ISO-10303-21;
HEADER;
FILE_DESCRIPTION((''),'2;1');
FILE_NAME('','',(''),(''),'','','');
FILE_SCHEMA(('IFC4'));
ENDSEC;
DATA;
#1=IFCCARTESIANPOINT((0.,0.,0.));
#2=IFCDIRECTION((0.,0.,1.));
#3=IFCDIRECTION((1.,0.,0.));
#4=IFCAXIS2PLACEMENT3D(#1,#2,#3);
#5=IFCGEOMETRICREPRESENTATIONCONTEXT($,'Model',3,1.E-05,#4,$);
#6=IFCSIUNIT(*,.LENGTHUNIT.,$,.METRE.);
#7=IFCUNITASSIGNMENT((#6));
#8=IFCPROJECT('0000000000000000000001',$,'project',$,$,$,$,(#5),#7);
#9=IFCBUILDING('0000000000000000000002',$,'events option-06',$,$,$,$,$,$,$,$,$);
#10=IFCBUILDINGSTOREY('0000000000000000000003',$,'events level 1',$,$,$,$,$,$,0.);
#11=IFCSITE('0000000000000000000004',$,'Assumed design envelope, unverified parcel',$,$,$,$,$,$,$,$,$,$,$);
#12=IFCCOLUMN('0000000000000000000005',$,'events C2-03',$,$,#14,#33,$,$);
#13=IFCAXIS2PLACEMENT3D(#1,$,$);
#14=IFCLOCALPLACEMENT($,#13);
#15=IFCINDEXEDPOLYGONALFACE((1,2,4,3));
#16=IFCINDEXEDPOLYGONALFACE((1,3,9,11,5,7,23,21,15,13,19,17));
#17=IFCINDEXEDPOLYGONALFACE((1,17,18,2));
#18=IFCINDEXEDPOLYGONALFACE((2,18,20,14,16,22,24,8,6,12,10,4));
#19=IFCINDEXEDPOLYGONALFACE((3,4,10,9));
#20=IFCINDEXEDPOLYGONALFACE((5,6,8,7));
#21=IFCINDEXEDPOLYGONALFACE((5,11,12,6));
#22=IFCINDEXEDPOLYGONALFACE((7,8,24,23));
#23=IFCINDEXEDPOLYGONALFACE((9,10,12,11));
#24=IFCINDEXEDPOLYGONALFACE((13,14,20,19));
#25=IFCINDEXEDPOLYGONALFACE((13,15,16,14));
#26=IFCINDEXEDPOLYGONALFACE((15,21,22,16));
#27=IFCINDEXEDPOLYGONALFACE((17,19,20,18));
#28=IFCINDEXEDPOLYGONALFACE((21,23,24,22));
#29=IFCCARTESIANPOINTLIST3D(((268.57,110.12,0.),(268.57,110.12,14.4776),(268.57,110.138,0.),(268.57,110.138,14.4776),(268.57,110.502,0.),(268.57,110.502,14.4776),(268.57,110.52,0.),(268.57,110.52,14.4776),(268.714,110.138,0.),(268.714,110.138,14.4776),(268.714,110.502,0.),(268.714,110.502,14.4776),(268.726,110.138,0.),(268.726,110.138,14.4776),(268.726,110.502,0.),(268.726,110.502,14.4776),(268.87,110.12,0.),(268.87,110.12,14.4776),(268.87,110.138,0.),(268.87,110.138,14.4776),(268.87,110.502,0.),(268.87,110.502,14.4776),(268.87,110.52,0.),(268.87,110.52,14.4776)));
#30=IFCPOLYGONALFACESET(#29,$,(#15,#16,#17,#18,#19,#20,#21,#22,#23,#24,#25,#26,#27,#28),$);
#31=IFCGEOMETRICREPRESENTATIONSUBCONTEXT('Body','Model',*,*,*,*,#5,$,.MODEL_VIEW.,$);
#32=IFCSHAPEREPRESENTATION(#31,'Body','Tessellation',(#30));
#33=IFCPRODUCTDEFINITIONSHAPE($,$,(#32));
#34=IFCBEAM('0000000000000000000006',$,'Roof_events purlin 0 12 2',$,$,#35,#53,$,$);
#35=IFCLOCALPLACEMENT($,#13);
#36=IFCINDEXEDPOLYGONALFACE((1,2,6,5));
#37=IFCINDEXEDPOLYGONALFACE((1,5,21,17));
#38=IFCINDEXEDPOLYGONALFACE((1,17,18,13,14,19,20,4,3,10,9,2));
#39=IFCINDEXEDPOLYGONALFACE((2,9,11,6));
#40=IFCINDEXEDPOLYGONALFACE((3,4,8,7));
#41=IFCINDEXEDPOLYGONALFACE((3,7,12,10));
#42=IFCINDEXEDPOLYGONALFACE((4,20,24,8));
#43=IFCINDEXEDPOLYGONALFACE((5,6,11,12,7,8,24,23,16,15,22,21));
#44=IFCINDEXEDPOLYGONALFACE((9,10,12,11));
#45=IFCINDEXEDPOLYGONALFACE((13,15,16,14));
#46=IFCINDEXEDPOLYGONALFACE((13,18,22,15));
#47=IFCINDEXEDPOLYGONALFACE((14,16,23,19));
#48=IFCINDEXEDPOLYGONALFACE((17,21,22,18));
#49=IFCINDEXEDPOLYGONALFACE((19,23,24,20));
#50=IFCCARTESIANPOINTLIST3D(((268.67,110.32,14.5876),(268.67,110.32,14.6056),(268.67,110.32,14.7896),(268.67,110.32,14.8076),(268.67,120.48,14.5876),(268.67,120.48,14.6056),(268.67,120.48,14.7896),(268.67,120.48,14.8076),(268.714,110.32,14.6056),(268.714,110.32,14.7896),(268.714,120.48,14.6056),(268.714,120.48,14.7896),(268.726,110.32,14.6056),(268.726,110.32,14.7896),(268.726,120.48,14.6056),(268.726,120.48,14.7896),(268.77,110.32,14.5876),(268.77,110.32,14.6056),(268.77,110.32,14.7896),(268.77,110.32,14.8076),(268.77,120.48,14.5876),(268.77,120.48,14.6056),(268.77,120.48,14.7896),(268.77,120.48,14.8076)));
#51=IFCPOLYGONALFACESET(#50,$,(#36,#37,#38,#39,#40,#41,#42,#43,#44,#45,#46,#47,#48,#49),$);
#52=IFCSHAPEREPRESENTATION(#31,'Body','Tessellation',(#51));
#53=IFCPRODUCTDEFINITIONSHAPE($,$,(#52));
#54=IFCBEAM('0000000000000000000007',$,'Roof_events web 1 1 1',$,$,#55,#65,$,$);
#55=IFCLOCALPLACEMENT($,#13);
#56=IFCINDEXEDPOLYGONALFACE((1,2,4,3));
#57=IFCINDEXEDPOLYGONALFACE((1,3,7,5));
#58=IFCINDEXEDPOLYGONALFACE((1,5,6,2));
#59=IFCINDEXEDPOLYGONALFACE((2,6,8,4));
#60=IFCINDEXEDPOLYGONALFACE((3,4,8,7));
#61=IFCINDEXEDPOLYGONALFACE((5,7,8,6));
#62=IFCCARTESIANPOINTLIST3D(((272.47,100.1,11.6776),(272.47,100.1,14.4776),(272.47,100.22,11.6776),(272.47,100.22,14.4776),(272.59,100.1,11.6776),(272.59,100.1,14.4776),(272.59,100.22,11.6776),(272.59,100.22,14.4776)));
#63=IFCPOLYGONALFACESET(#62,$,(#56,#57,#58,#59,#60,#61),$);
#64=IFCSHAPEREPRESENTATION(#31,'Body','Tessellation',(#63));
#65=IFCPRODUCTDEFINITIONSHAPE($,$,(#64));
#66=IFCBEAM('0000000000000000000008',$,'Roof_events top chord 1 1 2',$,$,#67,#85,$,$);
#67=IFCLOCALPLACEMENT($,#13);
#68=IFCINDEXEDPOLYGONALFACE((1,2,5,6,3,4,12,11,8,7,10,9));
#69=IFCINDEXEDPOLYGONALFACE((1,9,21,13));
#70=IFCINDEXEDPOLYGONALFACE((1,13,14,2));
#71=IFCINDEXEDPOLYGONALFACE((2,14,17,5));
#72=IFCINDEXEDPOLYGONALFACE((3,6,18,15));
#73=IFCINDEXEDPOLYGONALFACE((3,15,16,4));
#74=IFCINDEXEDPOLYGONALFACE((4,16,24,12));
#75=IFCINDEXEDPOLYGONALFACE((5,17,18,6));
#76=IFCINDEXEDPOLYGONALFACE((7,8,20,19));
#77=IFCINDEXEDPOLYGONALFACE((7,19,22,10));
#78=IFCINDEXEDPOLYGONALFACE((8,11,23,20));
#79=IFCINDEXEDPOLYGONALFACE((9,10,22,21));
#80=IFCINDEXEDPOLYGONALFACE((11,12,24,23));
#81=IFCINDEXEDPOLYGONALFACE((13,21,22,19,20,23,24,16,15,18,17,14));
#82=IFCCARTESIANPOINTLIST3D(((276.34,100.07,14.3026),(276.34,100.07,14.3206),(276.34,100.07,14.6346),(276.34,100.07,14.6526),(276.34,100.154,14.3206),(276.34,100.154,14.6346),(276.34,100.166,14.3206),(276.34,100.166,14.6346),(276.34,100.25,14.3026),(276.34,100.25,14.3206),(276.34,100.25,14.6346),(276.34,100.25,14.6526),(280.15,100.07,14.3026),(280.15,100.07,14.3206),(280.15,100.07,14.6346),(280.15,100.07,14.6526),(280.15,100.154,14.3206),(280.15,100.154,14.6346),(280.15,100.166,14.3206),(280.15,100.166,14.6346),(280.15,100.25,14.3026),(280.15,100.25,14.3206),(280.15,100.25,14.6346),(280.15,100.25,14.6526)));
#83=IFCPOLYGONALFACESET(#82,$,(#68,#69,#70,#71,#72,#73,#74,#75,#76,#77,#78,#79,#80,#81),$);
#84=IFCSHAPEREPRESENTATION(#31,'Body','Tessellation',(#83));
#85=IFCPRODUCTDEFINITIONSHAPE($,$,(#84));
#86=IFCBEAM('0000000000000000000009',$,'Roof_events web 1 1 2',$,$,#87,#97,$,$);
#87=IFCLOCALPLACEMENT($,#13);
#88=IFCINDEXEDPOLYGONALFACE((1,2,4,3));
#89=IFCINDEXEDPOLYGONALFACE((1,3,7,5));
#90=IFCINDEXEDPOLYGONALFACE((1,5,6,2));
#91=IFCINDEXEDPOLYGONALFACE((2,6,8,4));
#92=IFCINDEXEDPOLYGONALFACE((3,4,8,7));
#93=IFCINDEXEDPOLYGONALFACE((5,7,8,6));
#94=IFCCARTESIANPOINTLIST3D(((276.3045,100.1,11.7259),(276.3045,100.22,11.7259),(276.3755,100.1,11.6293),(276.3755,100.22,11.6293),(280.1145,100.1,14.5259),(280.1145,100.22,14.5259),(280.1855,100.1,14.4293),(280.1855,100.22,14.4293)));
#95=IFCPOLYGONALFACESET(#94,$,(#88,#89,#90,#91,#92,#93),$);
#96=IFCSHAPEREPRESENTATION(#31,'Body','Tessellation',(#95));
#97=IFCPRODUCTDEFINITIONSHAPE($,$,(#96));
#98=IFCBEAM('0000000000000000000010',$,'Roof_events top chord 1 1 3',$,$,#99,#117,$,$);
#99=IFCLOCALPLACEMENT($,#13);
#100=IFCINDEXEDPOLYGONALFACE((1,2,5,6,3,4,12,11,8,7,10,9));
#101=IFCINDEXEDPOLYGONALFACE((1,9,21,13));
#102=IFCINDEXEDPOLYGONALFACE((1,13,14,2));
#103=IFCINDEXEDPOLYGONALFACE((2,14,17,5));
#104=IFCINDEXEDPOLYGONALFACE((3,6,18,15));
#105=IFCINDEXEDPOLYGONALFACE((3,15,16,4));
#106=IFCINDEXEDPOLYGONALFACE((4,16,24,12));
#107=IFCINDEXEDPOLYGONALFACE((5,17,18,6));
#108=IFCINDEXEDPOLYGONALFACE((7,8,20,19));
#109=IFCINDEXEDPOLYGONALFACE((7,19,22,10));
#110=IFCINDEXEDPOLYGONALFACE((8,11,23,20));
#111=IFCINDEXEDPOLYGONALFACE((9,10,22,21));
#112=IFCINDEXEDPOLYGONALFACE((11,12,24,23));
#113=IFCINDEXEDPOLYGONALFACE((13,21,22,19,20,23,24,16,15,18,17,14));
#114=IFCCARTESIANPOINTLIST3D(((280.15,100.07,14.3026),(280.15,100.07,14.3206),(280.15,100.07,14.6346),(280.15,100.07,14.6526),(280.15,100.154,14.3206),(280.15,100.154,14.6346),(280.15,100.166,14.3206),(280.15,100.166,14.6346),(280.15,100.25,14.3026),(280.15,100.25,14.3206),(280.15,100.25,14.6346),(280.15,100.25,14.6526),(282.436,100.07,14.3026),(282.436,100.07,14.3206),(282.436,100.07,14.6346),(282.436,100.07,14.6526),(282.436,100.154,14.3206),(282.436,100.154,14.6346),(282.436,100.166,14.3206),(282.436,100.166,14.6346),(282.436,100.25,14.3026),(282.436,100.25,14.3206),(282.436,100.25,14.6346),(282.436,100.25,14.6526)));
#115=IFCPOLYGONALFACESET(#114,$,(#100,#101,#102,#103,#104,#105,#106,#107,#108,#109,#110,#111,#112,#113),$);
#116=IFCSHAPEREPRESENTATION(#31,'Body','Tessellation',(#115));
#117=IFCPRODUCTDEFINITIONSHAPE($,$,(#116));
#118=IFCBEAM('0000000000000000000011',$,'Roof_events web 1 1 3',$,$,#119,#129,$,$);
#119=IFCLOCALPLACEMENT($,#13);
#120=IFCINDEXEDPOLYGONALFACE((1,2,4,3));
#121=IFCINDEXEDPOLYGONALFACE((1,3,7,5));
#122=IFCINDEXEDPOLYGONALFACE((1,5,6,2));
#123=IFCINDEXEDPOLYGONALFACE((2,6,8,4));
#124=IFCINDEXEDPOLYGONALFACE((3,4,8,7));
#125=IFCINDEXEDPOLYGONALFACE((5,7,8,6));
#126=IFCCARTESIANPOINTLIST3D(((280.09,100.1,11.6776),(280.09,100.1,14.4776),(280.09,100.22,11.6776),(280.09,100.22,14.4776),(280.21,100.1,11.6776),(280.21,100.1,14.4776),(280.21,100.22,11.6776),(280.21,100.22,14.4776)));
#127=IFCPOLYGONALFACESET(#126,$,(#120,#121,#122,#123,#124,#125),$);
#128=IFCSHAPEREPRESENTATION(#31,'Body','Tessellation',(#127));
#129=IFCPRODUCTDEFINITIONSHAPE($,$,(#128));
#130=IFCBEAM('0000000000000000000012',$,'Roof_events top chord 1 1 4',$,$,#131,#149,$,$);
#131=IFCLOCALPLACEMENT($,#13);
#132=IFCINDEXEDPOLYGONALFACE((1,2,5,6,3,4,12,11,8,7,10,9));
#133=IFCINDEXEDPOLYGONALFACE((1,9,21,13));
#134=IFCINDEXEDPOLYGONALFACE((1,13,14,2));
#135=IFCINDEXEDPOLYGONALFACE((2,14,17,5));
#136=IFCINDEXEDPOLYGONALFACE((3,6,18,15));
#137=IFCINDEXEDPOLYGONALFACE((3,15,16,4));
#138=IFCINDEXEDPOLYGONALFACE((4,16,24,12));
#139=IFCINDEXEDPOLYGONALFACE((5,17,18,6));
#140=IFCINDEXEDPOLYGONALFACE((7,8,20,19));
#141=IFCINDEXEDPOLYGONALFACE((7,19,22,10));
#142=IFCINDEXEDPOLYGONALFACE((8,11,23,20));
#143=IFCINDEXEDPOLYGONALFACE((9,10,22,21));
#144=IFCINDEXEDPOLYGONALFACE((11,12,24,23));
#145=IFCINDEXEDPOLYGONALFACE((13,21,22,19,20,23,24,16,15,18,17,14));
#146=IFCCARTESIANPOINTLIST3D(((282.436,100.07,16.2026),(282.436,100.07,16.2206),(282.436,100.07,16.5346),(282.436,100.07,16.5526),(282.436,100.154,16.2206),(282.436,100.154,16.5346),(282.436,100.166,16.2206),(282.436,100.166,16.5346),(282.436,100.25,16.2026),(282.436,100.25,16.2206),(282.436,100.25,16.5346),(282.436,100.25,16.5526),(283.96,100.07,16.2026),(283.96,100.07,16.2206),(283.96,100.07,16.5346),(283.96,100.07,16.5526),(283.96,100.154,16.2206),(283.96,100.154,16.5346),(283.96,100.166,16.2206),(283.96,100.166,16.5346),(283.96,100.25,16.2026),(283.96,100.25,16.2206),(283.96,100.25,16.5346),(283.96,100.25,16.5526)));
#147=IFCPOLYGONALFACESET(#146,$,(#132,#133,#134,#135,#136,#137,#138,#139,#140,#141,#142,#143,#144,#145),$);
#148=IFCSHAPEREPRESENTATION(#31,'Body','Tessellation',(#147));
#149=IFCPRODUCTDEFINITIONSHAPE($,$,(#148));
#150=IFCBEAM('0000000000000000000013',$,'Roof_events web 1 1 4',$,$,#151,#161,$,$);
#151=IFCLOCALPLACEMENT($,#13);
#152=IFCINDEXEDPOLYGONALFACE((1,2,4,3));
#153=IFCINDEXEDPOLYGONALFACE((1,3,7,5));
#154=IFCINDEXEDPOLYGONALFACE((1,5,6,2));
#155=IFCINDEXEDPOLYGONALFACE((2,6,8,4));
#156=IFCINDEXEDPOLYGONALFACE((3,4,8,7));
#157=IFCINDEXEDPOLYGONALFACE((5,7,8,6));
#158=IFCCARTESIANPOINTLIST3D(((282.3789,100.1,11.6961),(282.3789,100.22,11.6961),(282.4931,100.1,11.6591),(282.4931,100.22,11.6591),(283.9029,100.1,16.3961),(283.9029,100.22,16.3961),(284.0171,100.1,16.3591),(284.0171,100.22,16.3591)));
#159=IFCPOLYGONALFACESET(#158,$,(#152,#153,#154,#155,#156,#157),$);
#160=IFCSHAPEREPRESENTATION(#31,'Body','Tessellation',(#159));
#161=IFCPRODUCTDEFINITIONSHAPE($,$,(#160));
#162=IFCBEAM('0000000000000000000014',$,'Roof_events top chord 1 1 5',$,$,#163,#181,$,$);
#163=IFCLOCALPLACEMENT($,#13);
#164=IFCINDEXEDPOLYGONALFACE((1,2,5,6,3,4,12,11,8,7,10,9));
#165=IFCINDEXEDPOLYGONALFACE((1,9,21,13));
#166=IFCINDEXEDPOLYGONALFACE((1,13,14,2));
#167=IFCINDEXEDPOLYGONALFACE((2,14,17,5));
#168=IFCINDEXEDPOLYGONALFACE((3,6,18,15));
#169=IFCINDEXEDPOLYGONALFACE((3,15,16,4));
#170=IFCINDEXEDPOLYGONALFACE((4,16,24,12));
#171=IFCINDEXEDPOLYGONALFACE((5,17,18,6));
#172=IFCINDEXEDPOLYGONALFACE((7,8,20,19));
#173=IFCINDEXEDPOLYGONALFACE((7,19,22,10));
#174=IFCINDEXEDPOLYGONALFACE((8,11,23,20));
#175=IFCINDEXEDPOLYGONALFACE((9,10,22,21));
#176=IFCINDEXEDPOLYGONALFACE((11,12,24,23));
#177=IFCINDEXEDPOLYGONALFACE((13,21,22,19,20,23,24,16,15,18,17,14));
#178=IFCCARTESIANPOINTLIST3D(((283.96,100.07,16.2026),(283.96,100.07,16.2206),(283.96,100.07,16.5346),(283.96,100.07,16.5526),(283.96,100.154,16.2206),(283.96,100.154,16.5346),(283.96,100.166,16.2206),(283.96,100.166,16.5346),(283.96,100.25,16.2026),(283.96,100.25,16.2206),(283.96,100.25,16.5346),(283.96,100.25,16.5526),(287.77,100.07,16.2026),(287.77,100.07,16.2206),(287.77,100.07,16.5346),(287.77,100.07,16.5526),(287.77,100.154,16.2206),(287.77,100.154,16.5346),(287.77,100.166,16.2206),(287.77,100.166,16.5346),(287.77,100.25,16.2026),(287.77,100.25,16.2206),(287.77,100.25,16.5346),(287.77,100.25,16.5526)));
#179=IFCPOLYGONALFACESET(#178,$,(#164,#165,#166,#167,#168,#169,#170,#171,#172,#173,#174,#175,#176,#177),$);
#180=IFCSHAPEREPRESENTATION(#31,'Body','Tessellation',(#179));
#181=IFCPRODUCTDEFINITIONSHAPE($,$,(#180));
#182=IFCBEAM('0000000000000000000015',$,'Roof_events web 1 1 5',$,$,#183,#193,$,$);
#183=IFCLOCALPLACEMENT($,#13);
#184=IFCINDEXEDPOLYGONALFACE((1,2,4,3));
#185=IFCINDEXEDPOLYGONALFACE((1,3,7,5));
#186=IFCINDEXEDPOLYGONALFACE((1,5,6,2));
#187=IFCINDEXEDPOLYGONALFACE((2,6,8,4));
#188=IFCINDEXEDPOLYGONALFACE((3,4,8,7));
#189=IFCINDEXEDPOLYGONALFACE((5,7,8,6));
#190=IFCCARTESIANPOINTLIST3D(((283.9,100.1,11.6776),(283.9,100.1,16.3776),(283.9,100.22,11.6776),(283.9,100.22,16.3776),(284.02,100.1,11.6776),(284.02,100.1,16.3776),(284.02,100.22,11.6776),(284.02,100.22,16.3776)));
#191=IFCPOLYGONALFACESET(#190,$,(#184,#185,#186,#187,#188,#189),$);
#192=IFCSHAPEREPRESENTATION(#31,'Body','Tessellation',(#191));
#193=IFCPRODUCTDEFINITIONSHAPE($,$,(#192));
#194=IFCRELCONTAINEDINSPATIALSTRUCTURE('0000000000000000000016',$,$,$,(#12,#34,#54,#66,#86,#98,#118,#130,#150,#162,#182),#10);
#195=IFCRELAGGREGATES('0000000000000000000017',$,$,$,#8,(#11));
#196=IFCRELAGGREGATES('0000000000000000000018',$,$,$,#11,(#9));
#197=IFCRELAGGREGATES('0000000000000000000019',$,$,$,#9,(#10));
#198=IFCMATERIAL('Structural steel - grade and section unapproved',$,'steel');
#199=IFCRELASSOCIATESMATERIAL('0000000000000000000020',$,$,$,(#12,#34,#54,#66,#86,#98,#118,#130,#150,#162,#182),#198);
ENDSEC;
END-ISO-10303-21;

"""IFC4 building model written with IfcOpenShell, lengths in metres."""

from ifc_helpers import new_model, si_unit, frame, origin_with_axes, place, context, subcontext, project, spatial, rectangle, i_section, extrude, material, element, save


model = new_model("IFC4")

# Units and contexts
model_context = context("Model", 3, precision=1e-05, world=origin_with_axes())
body_context = subcontext(model_context, "Body", "Model", "MODEL_VIEW")
ifc_project = project(units=[si_unit("LENGTHUNIT", "METRE")], contexts=[model_context])

# Site, building, storey
site = spatial("IfcSite", under=ifc_project, Name="Assumed design envelope, unverified parcel")
building = spatial("IfcBuilding", under=site, Name="events option-06")
storey = spatial("IfcBuildingStorey", under=building, Name="events level 1", Elevation=0.0)

# Column
ifc_material = material(Name="Structural steel - grade and section unapproved", Category="steel")
column_placement = place(None, frame((268.72, 110.32, 0.0), z_axis=(0.0, 0.0, 1.0), x_axis=(-1.0, 0.0, 0.0)))
element("IfcColumn", 1, at=column_placement, inside=storey, material=ifc_material, Name="events C2-03", context=body_context, shape_type="SweptSolid", body=[
    extrude(i_section(OverallWidth=0.3, OverallDepth=0.4, WebThickness=0.012, FlangeThickness=0.018, FilletRadius=0.0), origin_with_axes(), (0.0, 0.0, 1.0), 14.4776),
])

# Beams
beam_1_placement = place(None, frame((268.72, 110.32, 14.6976), z_axis=(0.0, 1.0, 0.0), x_axis=(-1.0, 0.0, 0.0)))
element("IfcBeam", 2, at=beam_1_placement, inside=storey, material=ifc_material, Name="Roof_events purlin 0 12 2", context=body_context, shape_type="SweptSolid", body=[
    extrude(i_section(OverallWidth=0.1, OverallDepth=0.22, WebThickness=0.012, FlangeThickness=0.018, FilletRadius=0.0), origin_with_axes(), (0.0, 0.0, 1.0), 10.16),
])
beam_2_placement = place(None, frame((272.53, 100.16, 11.6776), z_axis=(0.0, 0.0, 1.0), x_axis=(-1.0, 0.0, 0.0)))
element("IfcBeam", 3, at=beam_2_placement, inside=storey, material=ifc_material, Name="Roof_events web 1 1 1", context=body_context, shape_type="SweptSolid", body=[
    extrude(rectangle(XDim=0.12, YDim=0.12), origin_with_axes(), (0.0, 0.0, 1.0), 2.8),
])
beam_3_placement = place(None, frame((276.34, 100.16, 14.4776), z_axis=(1.0, 0.0, 0.0), x_axis=(0.0, 1.0, 0.0)))
element("IfcBeam", 4, at=beam_3_placement, inside=storey, material=ifc_material, Name="Roof_events top chord 1 1 2", context=body_context, shape_type="SweptSolid", body=[
    extrude(i_section(OverallWidth=0.18, OverallDepth=0.35, WebThickness=0.012, FlangeThickness=0.018, FilletRadius=0.0), origin_with_axes(), (0.0, 0.0, 1.0), 3.81),
])
beam_4_placement = place(None, frame((276.34, 100.16, 11.6776), z_axis=(0.805799, 0.0, 0.592189), x_axis=(0.0, 1.0, 0.0)))
element("IfcBeam", 5, at=beam_4_placement, inside=storey, material=ifc_material, Name="Roof_events web 1 1 2", context=body_context, shape_type="SweptSolid", body=[
    extrude(rectangle(XDim=0.12, YDim=0.12), origin_with_axes(), (0.0, 0.0, 1.0), 4.7282),
])
beam_5_placement = place(None, frame((280.15, 100.16, 14.4776), z_axis=(1.0, 0.0, 0.0), x_axis=(0.0, 1.0, 0.0)))
element("IfcBeam", 6, at=beam_5_placement, inside=storey, material=ifc_material, Name="Roof_events top chord 1 1 3", context=body_context, shape_type="SweptSolid", body=[
    extrude(i_section(OverallWidth=0.18, OverallDepth=0.35, WebThickness=0.012, FlangeThickness=0.018, FilletRadius=0.0), origin_with_axes(), (0.0, 0.0, 1.0), 2.286),
])
beam_6_placement = place(None, frame((280.15, 100.16, 11.6776), z_axis=(0.0, 0.0, 1.0), x_axis=(-1.0, 0.0, 0.0)))
element("IfcBeam", 7, at=beam_6_placement, inside=storey, material=ifc_material, Name="Roof_events web 1 1 3", context=body_context, shape_type="SweptSolid", body=[
    extrude(rectangle(XDim=0.12, YDim=0.12), origin_with_axes(), (0.0, 0.0, 1.0), 2.8),
])
beam_7_placement = place(None, frame((282.436, 100.16, 16.3776), z_axis=(1.0, 0.0, 0.0), x_axis=(0.0, 1.0, 0.0)))
element("IfcBeam", 8, at=beam_7_placement, inside=storey, material=ifc_material, Name="Roof_events top chord 1 1 4", context=body_context, shape_type="SweptSolid", body=[
    extrude(i_section(OverallWidth=0.18, OverallDepth=0.35, WebThickness=0.012, FlangeThickness=0.018, FilletRadius=0.0), origin_with_axes(), (0.0, 0.0, 1.0), 1.524),
])
beam_8_placement = place(None, frame((282.436, 100.16, 11.6776), z_axis=(0.308443, 0.0, 0.951243), x_axis=(0.0, 1.0, 0.0)))
element("IfcBeam", 9, at=beam_8_placement, inside=storey, material=ifc_material, Name="Roof_events web 1 1 4", context=body_context, shape_type="SweptSolid", body=[
    extrude(rectangle(XDim=0.12, YDim=0.12), origin_with_axes(), (0.0, 0.0, 1.0), 4.9409),
])
beam_9_placement = place(None, frame((283.96, 100.16, 16.3776), z_axis=(1.0, 0.0, 0.0), x_axis=(0.0, 1.0, 0.0)))
element("IfcBeam", 10, at=beam_9_placement, inside=storey, material=ifc_material, Name="Roof_events top chord 1 1 5", context=body_context, shape_type="SweptSolid", body=[
    extrude(i_section(OverallWidth=0.18, OverallDepth=0.35, WebThickness=0.012, FlangeThickness=0.018, FilletRadius=0.0), origin_with_axes(), (0.0, 0.0, 1.0), 3.81),
])
beam_10_placement = place(None, frame((283.96, 100.16, 11.6776), z_axis=(0.0, 0.0, 1.0), x_axis=(-1.0, 0.0, 0.0)))
element("IfcBeam", 11, at=beam_10_placement, inside=storey, material=ifc_material, Name="Roof_events web 1 1 5", context=body_context, shape_type="SweptSolid", body=[
    extrude(rectangle(XDim=0.12, YDim=0.12), origin_with_axes(), (0.0, 0.0, 1.0), 4.7),
])

save(model, "model.ifc")
